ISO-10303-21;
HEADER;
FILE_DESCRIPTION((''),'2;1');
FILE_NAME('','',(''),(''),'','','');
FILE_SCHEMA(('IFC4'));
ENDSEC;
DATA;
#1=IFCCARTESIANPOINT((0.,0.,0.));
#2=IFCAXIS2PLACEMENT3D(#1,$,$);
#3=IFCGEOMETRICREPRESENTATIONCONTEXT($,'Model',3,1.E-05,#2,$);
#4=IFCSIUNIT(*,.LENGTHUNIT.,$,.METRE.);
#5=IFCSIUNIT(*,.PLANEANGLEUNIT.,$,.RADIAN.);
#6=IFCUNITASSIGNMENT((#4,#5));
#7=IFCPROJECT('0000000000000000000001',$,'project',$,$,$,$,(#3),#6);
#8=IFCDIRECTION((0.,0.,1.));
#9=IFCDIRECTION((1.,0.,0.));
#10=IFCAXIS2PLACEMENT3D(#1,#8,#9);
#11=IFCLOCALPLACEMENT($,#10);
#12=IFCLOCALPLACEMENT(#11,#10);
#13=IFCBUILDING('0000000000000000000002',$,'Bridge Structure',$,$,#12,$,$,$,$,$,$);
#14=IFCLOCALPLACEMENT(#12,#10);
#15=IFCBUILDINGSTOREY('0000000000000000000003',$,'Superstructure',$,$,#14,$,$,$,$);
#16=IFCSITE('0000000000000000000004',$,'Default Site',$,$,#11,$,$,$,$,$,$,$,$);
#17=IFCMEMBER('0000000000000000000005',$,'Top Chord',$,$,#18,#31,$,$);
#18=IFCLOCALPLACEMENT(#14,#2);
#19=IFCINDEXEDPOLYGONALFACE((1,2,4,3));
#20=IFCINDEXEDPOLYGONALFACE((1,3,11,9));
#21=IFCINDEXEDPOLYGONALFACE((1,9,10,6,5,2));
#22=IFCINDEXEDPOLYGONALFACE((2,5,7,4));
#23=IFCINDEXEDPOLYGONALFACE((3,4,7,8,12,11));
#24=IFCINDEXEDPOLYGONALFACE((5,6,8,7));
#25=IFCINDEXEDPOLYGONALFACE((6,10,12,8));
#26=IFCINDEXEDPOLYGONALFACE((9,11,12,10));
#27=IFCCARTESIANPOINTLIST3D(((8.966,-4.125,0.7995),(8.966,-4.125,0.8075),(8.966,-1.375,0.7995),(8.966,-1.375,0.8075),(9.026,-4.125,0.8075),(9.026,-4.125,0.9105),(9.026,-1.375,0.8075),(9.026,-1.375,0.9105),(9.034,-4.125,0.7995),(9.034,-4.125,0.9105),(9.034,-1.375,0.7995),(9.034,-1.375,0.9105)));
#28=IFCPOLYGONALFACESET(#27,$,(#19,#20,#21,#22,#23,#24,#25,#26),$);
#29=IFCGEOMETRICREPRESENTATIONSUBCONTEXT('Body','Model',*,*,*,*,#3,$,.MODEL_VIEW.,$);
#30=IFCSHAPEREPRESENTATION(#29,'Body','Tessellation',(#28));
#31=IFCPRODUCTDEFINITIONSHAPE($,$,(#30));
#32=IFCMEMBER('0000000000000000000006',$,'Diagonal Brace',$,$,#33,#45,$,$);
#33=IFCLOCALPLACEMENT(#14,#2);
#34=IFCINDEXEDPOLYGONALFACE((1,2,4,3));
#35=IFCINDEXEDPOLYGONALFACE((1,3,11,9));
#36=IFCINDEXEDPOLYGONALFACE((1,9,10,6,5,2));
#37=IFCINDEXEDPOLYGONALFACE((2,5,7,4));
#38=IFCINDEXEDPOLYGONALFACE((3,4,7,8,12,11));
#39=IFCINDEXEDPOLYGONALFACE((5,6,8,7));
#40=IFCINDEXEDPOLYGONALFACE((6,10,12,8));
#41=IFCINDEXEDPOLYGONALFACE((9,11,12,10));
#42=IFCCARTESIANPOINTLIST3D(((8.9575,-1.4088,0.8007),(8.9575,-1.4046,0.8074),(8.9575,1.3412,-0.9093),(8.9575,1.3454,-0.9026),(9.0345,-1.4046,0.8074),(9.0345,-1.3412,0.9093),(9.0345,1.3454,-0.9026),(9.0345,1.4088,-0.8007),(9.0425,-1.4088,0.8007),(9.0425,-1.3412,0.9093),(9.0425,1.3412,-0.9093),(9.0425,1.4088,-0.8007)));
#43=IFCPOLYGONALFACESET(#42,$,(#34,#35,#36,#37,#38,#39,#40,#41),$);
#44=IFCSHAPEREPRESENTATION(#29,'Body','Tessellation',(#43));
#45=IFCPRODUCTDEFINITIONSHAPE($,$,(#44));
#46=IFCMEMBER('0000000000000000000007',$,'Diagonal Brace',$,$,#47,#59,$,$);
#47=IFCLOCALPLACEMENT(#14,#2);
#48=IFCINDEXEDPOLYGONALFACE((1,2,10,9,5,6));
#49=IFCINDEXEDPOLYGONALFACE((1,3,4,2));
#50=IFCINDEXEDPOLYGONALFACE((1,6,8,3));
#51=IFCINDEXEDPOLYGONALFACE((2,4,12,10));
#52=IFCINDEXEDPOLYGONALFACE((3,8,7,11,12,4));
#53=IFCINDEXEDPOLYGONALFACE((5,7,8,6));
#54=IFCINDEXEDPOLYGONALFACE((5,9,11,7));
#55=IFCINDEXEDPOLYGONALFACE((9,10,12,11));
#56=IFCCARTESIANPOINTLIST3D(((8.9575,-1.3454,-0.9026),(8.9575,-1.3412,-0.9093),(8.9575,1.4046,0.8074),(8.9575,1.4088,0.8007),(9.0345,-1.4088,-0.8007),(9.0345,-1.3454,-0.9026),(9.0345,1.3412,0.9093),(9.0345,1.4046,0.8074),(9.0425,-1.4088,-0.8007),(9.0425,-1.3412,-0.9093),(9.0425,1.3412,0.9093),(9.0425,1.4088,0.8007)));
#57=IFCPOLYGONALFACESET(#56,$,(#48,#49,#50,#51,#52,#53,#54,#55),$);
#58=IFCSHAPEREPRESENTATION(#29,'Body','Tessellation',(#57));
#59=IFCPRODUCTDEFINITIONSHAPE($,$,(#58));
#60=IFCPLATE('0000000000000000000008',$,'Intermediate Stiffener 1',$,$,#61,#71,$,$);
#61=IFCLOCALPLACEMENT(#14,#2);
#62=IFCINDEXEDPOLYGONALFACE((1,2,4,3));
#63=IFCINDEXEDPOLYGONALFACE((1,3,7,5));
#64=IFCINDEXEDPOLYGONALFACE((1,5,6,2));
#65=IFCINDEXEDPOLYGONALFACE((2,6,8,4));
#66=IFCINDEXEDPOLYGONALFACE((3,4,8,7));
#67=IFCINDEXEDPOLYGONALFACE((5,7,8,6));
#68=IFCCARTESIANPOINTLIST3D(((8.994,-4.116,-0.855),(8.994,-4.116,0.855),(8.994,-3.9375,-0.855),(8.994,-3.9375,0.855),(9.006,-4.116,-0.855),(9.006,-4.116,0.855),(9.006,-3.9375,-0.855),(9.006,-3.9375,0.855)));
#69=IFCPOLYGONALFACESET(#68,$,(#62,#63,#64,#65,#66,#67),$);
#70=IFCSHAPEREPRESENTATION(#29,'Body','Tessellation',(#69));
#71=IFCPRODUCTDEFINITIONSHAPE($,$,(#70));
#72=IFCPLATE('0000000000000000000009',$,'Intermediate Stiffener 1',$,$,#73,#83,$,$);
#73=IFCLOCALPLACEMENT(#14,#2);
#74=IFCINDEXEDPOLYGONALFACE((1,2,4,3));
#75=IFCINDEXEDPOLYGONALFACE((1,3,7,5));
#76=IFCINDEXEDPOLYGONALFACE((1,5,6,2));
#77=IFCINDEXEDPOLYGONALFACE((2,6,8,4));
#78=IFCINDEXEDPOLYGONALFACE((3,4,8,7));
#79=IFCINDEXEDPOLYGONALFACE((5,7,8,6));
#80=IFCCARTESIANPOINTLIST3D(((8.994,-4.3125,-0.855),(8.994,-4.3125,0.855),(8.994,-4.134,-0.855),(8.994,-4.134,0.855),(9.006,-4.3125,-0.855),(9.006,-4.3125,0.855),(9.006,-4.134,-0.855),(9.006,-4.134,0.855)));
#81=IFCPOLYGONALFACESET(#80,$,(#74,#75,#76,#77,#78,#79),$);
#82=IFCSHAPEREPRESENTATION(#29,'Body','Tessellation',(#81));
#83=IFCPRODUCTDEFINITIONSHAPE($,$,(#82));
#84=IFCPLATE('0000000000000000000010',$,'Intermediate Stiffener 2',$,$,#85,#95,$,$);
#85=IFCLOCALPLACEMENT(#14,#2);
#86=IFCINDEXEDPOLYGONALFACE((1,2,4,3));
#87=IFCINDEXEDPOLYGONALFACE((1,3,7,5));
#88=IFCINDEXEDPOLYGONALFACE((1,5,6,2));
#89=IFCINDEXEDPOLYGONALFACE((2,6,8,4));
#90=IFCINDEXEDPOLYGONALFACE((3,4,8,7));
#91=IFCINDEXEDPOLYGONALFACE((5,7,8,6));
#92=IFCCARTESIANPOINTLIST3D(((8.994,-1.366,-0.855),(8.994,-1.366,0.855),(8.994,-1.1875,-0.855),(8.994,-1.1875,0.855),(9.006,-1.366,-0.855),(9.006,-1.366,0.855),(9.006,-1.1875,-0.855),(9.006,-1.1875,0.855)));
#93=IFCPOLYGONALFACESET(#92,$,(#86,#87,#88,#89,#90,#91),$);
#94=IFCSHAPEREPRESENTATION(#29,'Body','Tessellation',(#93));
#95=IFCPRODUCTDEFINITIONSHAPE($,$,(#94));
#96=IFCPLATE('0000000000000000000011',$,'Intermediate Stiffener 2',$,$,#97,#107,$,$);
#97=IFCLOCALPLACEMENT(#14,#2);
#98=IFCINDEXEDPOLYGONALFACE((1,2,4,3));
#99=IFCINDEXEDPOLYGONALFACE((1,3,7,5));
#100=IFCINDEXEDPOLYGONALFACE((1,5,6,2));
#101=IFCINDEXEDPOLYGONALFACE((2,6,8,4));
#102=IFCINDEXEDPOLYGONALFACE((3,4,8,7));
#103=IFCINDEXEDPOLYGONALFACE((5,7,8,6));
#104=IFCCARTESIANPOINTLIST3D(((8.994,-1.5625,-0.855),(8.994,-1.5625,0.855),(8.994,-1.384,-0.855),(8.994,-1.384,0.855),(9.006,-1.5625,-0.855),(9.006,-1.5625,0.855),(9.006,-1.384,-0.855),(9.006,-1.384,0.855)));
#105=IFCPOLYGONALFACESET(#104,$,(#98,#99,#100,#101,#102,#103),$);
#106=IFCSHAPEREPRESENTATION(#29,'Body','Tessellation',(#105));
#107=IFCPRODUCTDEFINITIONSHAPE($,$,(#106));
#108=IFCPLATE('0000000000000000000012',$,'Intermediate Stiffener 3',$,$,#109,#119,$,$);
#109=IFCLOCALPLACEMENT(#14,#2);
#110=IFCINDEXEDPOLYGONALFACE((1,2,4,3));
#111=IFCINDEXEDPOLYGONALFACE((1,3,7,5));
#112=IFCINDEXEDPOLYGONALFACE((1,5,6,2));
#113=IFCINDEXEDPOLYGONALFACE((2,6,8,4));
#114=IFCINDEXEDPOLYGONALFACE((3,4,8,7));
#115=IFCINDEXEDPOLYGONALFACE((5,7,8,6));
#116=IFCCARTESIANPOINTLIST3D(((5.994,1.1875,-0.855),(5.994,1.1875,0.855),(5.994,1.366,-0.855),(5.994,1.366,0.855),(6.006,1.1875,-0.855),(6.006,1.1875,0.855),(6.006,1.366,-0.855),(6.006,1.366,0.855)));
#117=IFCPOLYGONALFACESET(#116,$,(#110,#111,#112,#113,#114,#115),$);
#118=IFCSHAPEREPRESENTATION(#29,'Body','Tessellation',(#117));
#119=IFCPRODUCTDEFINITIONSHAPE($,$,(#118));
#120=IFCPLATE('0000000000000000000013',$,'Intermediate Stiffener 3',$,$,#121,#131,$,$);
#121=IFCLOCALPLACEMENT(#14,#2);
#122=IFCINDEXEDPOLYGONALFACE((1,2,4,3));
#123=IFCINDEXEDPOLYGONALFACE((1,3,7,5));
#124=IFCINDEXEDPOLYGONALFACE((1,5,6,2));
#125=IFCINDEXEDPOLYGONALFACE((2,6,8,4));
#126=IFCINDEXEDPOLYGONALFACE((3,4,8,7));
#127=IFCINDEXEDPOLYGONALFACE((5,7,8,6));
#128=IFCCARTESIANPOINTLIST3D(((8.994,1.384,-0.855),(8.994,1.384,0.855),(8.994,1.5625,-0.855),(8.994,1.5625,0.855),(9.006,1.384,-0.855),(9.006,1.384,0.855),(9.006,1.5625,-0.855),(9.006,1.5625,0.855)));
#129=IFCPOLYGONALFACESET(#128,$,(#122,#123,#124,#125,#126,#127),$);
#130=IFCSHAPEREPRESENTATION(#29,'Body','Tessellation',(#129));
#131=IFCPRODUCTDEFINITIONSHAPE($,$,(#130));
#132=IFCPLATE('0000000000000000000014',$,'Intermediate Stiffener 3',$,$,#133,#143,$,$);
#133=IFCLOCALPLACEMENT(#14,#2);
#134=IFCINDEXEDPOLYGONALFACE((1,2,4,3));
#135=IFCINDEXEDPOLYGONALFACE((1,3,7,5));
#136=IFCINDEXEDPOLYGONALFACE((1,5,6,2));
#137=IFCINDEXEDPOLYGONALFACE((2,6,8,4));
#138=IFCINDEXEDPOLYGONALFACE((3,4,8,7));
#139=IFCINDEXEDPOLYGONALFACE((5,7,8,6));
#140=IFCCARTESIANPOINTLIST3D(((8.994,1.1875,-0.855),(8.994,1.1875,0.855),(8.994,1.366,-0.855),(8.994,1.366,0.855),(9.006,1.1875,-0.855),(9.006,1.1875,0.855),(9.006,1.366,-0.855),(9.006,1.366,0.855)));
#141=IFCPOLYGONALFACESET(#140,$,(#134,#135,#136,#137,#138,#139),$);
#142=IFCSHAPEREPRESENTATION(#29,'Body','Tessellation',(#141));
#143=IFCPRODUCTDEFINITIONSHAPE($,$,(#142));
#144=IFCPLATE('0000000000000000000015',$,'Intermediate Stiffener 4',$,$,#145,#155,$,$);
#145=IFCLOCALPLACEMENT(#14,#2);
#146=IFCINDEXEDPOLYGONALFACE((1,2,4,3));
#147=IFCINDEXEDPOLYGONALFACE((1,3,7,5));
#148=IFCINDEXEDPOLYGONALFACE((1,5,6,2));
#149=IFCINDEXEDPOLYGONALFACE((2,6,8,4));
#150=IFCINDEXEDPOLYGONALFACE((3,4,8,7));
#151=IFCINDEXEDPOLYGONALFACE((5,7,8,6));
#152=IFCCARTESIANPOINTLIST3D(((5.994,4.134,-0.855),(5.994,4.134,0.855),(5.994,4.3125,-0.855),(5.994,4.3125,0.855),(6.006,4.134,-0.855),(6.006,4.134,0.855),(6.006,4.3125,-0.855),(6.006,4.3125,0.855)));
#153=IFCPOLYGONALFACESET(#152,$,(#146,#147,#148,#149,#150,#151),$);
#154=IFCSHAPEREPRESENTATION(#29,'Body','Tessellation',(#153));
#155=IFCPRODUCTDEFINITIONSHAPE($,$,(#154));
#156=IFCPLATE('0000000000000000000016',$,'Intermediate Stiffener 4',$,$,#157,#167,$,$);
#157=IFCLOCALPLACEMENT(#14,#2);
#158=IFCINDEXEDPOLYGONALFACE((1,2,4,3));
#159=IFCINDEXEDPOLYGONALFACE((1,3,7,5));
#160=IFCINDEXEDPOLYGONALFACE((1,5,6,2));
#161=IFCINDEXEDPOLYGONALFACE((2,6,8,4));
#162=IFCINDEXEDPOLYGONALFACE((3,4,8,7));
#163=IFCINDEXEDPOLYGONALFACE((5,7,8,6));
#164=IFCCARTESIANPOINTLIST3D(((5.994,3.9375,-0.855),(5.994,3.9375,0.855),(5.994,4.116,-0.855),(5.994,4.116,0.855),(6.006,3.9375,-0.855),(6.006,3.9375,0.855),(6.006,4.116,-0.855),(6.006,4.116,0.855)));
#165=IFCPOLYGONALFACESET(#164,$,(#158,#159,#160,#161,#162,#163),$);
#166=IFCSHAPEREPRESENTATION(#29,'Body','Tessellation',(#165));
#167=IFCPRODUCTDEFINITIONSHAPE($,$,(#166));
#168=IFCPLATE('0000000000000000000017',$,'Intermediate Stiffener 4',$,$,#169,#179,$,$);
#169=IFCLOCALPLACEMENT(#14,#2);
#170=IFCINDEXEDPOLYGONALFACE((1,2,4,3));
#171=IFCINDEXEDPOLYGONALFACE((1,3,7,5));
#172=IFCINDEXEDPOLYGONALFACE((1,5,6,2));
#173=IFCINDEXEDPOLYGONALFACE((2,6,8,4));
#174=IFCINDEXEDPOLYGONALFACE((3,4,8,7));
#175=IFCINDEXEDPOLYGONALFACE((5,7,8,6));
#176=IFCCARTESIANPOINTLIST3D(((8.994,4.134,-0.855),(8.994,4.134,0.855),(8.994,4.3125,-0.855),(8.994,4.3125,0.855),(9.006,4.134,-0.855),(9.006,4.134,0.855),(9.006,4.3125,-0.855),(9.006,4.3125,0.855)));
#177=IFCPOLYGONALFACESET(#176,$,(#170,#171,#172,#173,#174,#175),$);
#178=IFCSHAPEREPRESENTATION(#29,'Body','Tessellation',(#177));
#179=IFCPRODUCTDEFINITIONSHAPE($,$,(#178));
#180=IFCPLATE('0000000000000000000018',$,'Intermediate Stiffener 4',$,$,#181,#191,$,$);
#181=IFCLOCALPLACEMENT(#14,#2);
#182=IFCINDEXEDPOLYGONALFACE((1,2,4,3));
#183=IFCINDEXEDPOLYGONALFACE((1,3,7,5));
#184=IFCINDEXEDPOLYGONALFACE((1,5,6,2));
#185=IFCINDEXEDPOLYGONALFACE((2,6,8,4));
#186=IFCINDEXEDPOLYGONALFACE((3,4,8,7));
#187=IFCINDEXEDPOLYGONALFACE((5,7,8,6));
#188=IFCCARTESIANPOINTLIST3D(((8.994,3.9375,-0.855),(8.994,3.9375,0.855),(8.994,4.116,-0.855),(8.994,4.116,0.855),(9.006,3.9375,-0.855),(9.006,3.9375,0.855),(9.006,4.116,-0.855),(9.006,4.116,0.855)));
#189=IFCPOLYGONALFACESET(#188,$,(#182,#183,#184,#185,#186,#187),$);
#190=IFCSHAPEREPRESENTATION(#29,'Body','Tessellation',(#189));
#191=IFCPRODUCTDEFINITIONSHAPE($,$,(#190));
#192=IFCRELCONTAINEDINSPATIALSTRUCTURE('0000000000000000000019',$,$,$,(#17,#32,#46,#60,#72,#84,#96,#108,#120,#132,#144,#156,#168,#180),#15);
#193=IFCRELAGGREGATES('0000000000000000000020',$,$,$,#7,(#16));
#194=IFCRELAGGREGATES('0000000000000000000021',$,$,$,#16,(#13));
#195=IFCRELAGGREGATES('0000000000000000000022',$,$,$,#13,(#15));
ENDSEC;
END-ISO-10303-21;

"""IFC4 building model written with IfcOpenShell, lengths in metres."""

from ifc_helpers import new_model, si_unit, frame, origin, origin_with_axes, origin_2d_with_axis, place, context, subcontext, project, spatial, rectangle, l_section, extrude, element, save


model = new_model("IFC4")

# Units and contexts
model_context = context("Model", 3, precision=1e-05, world=origin())
body_context = subcontext(model_context, "Body", "Model", "MODEL_VIEW")
ifc_project = project(units=[si_unit("LENGTHUNIT", "METRE"), si_unit("PLANEANGLEUNIT", "RADIAN")], contexts=[model_context])

# Site, building, storey
site_placement = place(None, origin_with_axes())
site = spatial("IfcSite", under=ifc_project, at=site_placement, Name="Default Site")
building_placement = place(site_placement, origin_with_axes())
building = spatial("IfcBuilding", under=site, at=building_placement, Name="Bridge Structure")
storey_placement = place(building_placement, origin_with_axes())
storey = spatial("IfcBuildingStorey", under=building, at=storey_placement, Name="Superstructure")

# Members
for number, where, z_axis, x_axis, name in (
    (1, (9.0, -4.125, 0.855), (0.0, 1.0, 0.0), (-1.0, 0.0, 0.0), "Top Chord"),
):
    element("IfcMember", number, at=place(storey_placement, frame(where, z_axis=z_axis, x_axis=x_axis)), inside=storey, Name=name, context=body_context, shape_type="SweptSolid", body=[
        extrude(l_section(Depth=0.111, Width=0.068, Thickness=0.008, at=origin_2d_with_axis()), origin_with_axes(), (0.0, 0.0, 1.0), 2.75),
    ])
for number, where, z_axis, x_axis, name in (
    (2, (9.0, -1.375, 0.855), (0.0, 0.84921, -0.528055), (-1.0, 0.0, 0.0), "Diagonal Brace"),
    (3, (9.0, -1.375, -0.855), (0.0, 0.84921, 0.528055), (-1.0, 0.0, 0.0), "Diagonal Brace"),
):
    element("IfcMember", number, at=place(storey_placement, frame(where, z_axis=z_axis, x_axis=x_axis)), inside=storey, Name=name, context=body_context, shape_type="SweptSolid", body=[
        extrude(l_section(Depth=0.128, Width=0.085, Thickness=0.008, at=origin_2d_with_axis()), origin_with_axes(), (0.0, 0.0, 1.0), 3.2383),
    ])

# Plates
for number, where, z_axis, x_axis, name in (
    (4, (9.0, -4.0267, -0.855), (0.0, 0.0, 1.0), (1.0, 0.0, 0.0), "Intermediate Stiffener 1"),
    (5, (9.0, -4.2233, -0.855), (0.0, 0.0, 1.0), (1.0, 0.0, 0.0), "Intermediate Stiffener 1"),
    (6, (9.0, -1.2768, -0.855), (0.0, 0.0, 1.0), (1.0, 0.0, 0.0), "Intermediate Stiffener 2"),
    (7, (9.0, -1.4732, -0.855), (0.0, 0.0, 1.0), (1.0, 0.0, 0.0), "Intermediate Stiffener 2"),
    (8, (6.0, 1.2768, -0.855), (0.0, 0.0, 1.0), (1.0, 0.0, 0.0), "Intermediate Stiffener 3"),
    (9, (9.0, 1.4732, -0.855), (0.0, 0.0, 1.0), (1.0, 0.0, 0.0), "Intermediate Stiffener 3"),
    (10, (9.0, 1.2768, -0.855), (0.0, 0.0, 1.0), (1.0, 0.0, 0.0), "Intermediate Stiffener 3"),
    (11, (6.0, 4.2233, -0.855), (0.0, 0.0, 1.0), (1.0, 0.0, 0.0), "Intermediate Stiffener 4"),
    (12, (6.0, 4.0267, -0.855), (0.0, 0.0, 1.0), (1.0, 0.0, 0.0), "Intermediate Stiffener 4"),
    (13, (9.0, 4.2233, -0.855), (0.0, 0.0, 1.0), (1.0, 0.0, 0.0), "Intermediate Stiffener 4"),
    (14, (9.0, 4.0267, -0.855), (0.0, 0.0, 1.0), (1.0, 0.0, 0.0), "Intermediate Stiffener 4"),
):
    element("IfcPlate", number, at=place(storey_placement, frame(where, z_axis=z_axis, x_axis=x_axis)), inside=storey, Name=name, context=body_context, shape_type="SweptSolid", body=[
        extrude(rectangle(XDim=0.012, YDim=0.1785, at=origin_2d_with_axis()), origin_with_axes(), (0.0, 0.0, 1.0), 1.71),
    ])

save(model, "model.ifc")
